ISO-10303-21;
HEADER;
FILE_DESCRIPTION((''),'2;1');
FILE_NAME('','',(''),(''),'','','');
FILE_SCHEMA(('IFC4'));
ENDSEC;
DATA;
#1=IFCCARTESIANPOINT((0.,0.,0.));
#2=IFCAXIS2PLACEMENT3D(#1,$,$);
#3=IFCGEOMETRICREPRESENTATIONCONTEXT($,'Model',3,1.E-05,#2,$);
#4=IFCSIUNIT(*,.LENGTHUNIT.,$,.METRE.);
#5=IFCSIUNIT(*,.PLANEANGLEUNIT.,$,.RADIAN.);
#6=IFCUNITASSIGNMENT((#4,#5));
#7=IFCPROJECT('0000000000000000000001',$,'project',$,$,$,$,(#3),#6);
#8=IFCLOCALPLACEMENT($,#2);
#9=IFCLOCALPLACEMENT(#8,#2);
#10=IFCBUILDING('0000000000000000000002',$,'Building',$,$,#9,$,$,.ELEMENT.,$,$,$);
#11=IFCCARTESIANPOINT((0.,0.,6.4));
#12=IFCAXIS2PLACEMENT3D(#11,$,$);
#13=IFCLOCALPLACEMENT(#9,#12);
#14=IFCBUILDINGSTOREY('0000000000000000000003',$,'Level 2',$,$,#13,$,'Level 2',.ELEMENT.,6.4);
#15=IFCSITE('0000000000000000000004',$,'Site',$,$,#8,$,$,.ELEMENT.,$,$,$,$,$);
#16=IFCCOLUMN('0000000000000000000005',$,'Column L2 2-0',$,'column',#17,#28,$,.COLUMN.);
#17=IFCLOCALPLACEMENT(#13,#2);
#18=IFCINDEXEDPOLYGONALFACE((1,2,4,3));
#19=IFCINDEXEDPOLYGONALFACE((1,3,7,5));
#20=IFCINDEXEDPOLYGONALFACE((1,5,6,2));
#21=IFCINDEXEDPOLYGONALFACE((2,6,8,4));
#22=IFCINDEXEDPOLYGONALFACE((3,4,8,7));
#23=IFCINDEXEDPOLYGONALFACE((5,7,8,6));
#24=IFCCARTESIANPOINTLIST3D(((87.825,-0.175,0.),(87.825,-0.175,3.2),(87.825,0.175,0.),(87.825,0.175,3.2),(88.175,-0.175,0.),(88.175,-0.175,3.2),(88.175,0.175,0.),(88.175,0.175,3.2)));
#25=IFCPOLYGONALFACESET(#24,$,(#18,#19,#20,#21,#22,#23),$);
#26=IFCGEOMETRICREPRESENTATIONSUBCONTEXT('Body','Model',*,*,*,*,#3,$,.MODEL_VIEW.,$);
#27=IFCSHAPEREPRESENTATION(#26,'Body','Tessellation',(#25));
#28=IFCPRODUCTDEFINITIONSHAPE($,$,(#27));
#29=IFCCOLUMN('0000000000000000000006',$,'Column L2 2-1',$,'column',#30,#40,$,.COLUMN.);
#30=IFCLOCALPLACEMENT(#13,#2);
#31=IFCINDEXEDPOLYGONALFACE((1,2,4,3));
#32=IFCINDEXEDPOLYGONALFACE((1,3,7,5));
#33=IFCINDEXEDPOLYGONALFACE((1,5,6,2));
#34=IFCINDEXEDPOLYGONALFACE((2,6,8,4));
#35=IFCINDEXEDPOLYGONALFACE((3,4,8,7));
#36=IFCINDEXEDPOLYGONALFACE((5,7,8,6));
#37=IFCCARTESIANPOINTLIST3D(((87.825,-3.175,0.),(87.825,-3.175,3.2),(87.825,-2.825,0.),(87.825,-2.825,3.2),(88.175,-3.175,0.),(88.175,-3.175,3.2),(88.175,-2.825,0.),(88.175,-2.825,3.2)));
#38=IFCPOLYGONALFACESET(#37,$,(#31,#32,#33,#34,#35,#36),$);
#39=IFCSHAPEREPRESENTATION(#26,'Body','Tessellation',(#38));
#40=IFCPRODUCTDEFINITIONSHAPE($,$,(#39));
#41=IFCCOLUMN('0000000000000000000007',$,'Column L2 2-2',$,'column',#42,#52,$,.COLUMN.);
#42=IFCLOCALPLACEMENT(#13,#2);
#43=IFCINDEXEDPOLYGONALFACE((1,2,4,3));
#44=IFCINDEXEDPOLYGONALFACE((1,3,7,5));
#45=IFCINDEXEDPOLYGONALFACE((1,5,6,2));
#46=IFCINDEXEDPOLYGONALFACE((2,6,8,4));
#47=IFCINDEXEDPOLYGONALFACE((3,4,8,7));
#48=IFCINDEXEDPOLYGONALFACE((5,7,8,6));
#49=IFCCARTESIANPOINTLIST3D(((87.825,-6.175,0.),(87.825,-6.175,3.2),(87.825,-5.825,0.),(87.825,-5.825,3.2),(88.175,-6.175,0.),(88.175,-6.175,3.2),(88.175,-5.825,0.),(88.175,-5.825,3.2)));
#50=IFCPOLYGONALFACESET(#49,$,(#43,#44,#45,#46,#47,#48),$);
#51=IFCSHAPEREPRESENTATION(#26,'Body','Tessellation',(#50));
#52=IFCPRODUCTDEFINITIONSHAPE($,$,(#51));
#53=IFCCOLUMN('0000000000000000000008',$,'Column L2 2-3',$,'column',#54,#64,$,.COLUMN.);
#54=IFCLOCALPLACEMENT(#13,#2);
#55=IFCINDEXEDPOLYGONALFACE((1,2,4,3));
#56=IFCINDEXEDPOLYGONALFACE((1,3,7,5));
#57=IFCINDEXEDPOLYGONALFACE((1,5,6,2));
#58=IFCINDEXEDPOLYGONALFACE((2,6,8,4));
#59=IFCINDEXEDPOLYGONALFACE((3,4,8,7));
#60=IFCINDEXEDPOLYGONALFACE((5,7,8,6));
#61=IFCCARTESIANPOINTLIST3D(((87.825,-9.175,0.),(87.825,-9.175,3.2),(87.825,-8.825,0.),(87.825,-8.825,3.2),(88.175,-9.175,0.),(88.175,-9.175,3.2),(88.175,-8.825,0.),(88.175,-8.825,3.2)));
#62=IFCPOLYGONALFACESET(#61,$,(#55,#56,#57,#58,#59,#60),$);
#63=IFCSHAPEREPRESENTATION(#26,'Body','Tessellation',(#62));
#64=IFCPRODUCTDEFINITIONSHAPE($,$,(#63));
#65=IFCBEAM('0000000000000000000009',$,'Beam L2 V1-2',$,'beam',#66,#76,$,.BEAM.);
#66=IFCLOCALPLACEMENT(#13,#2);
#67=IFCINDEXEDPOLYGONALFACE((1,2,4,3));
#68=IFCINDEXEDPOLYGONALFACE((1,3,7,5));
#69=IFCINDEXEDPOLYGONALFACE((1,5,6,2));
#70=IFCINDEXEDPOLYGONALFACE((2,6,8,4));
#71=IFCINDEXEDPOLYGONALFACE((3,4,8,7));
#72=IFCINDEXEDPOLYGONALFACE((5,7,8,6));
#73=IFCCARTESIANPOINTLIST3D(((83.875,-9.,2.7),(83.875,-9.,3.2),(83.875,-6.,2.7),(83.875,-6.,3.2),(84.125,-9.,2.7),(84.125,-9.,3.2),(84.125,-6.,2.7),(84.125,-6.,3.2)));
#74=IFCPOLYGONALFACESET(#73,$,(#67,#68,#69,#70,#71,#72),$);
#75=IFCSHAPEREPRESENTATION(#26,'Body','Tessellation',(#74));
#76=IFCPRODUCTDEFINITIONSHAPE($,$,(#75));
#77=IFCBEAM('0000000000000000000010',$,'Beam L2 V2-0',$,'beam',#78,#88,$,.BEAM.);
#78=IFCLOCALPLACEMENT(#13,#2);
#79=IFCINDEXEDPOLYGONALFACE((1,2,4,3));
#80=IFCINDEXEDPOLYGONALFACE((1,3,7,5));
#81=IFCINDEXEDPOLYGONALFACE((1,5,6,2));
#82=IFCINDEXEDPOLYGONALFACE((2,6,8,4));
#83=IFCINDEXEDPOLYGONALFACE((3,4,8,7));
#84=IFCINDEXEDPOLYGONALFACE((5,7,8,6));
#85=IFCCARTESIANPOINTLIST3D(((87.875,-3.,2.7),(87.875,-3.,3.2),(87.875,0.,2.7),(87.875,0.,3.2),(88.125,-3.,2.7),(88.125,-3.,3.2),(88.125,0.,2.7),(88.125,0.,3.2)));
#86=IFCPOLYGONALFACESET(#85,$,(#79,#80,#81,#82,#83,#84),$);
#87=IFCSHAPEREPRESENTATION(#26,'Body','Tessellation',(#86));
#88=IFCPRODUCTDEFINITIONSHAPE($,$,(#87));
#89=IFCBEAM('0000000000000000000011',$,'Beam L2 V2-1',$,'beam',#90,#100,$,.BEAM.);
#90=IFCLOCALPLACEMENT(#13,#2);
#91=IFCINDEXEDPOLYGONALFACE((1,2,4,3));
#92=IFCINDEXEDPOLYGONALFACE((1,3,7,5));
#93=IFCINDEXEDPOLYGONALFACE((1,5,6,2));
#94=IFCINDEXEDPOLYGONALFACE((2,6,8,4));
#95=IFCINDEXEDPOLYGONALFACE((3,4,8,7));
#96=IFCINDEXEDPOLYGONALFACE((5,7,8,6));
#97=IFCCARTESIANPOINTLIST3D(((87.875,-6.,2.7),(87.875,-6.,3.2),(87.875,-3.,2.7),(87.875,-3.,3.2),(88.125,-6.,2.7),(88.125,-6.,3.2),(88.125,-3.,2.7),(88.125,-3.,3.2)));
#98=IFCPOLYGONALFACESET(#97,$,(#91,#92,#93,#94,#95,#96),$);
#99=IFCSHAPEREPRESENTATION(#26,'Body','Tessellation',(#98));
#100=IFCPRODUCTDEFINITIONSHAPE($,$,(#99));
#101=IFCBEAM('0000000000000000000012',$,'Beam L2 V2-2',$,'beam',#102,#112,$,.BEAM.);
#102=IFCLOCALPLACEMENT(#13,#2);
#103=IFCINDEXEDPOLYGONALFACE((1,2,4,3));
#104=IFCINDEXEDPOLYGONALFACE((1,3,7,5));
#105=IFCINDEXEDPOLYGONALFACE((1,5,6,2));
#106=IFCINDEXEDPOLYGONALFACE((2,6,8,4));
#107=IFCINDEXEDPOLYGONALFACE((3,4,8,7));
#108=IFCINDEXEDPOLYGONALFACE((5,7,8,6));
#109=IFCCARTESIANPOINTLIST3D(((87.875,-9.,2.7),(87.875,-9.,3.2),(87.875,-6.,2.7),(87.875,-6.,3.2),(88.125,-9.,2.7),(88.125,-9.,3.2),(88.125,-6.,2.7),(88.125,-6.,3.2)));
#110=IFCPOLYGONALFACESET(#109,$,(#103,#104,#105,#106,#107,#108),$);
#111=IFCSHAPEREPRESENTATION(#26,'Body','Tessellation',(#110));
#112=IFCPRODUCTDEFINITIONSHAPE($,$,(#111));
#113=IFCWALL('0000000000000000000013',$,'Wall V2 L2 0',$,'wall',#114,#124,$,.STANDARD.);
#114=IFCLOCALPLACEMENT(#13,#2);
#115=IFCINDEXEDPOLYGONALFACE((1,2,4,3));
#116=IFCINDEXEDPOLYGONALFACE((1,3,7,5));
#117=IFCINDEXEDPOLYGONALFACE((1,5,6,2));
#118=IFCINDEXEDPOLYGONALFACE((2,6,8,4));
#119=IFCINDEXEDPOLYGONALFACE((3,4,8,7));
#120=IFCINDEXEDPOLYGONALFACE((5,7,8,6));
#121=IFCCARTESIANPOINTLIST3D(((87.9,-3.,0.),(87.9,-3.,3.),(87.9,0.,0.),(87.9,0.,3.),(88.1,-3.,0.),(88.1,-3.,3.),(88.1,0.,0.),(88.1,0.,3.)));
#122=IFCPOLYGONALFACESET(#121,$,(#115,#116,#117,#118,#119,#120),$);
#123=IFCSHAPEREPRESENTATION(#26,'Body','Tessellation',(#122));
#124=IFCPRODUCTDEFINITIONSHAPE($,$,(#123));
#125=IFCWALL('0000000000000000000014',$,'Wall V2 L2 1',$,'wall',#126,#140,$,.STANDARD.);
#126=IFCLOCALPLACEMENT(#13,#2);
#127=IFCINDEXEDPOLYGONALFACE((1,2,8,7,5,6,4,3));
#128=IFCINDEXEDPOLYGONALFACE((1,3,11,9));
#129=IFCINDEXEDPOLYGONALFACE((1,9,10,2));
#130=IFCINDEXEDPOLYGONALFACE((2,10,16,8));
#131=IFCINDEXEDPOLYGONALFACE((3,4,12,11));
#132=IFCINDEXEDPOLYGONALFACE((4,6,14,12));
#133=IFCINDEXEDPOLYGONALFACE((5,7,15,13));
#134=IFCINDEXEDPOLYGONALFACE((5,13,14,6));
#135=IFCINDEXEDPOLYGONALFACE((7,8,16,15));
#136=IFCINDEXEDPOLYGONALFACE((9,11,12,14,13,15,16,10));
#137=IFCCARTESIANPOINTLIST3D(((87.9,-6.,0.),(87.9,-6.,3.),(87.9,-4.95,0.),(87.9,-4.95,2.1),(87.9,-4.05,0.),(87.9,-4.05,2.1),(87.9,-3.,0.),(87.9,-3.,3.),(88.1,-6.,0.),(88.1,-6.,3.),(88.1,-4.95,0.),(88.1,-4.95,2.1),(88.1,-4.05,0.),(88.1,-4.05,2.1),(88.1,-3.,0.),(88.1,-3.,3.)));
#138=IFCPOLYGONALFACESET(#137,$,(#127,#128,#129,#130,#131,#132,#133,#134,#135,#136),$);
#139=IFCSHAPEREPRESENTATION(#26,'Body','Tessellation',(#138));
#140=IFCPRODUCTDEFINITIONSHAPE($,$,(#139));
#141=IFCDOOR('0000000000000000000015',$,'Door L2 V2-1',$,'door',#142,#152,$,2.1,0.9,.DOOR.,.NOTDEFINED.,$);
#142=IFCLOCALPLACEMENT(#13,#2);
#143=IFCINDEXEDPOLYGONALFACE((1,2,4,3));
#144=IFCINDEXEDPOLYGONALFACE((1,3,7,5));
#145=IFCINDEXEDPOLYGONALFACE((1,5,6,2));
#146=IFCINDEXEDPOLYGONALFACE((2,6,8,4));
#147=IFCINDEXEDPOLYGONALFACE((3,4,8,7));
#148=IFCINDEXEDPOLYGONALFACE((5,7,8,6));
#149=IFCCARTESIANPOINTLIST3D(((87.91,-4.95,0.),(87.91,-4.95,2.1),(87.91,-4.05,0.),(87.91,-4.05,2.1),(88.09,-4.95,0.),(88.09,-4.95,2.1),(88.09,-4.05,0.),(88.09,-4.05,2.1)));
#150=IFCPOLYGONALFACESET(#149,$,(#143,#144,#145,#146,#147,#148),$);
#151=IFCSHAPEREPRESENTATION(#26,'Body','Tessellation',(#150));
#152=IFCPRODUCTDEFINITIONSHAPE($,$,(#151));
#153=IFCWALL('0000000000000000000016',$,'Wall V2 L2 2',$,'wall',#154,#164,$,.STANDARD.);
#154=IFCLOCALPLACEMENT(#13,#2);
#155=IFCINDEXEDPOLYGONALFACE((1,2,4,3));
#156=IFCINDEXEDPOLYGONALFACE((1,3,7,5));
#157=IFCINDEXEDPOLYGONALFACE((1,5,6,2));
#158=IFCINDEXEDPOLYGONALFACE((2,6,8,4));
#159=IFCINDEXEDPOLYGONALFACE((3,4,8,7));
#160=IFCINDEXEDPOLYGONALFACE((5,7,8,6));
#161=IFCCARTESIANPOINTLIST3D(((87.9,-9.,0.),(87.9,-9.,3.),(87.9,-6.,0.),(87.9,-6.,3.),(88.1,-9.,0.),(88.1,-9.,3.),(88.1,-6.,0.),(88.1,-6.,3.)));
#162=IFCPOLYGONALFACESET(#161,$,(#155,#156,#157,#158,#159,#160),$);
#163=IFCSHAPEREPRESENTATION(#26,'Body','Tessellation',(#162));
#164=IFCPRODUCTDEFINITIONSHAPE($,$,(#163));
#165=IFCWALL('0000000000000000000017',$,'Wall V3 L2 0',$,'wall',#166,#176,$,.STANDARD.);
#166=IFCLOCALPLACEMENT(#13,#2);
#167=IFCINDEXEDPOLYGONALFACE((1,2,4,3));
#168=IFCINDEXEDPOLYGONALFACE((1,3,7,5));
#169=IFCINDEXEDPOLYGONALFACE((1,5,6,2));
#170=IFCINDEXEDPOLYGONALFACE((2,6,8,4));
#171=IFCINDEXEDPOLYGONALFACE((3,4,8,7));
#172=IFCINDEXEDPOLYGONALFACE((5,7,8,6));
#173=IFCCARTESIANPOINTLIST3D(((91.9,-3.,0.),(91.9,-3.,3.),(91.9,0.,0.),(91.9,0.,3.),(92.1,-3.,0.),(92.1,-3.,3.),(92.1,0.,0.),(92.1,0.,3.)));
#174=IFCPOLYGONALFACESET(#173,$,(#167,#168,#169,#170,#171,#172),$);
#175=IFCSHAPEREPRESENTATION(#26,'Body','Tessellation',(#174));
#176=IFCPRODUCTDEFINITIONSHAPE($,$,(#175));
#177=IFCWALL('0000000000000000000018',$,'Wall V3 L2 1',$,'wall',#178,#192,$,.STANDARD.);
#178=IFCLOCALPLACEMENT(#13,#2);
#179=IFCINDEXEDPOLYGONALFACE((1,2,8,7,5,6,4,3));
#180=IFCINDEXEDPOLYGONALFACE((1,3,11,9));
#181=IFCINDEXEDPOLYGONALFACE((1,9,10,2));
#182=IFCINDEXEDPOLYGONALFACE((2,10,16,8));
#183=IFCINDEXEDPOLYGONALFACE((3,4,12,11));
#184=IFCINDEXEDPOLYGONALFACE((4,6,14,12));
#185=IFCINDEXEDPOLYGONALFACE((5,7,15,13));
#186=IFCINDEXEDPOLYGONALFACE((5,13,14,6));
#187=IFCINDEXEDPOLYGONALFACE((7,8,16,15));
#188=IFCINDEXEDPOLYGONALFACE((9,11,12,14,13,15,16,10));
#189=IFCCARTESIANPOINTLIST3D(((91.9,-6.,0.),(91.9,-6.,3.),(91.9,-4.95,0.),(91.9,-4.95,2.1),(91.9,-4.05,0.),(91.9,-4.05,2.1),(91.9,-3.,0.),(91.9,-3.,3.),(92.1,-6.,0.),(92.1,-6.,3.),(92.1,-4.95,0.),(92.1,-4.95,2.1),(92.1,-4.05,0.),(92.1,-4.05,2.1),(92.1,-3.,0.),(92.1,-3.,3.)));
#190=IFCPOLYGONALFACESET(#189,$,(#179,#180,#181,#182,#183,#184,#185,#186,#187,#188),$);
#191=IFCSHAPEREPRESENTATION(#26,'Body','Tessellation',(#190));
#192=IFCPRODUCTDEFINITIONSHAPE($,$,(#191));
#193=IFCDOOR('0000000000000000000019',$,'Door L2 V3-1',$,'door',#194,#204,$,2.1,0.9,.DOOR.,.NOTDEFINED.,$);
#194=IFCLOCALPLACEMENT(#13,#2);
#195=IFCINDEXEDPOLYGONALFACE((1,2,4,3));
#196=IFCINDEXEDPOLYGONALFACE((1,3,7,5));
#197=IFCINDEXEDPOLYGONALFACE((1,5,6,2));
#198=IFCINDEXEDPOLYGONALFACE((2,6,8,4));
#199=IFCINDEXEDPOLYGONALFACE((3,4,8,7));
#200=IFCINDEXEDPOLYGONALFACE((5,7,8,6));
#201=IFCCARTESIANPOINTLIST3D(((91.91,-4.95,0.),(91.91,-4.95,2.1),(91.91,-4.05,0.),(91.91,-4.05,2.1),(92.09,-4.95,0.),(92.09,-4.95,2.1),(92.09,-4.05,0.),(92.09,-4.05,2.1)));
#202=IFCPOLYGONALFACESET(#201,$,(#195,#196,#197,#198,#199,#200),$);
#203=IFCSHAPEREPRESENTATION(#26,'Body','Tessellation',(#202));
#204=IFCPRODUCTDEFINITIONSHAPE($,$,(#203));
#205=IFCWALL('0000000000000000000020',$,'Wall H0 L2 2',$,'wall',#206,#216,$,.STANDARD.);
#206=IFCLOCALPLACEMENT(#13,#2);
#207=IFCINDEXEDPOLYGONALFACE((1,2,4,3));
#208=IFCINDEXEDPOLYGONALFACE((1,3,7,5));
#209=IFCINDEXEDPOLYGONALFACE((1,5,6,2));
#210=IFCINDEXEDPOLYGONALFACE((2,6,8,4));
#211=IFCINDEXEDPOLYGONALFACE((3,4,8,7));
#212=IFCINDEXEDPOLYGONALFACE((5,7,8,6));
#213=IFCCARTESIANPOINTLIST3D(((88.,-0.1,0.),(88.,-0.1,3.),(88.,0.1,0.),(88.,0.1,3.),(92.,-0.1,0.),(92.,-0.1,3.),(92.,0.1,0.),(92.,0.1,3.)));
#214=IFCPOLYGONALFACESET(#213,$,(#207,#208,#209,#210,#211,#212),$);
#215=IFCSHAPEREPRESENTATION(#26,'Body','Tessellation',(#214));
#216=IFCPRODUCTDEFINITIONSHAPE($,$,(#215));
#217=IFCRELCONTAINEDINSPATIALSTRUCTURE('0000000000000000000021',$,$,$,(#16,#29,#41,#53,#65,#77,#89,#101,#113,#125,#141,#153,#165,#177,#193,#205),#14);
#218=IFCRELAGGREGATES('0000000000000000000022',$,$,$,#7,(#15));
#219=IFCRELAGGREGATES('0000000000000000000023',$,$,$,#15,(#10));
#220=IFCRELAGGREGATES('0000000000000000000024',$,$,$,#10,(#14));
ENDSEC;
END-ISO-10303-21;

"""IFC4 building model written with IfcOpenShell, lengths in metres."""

from ifc_helpers import new_model, si_unit, frame, frame_2d, origin, origin_2d, place, context, subcontext, project, spatial, rectangle, extrude, element, fill, save


model = new_model("IFC4")

# Units and contexts
model_context = context("Model", 3, precision=1e-05, world=origin())
body_context = subcontext(model_context, "Body", "Model", "MODEL_VIEW")
ifc_project = project(units=[si_unit("LENGTHUNIT", "METRE"), si_unit("PLANEANGLEUNIT", "RADIAN")], contexts=[model_context])

# Site, building, storey
site_placement = place(None, origin())
site = spatial("IfcSite", under=ifc_project, at=site_placement, Name="Site", CompositionType="ELEMENT")
building_placement = place(site_placement, origin())
building = spatial("IfcBuilding", under=site, at=building_placement, Name="Building", CompositionType="ELEMENT")
storey_placement = place(building_placement, frame((0.0, 0.0, 6.4)))
storey = spatial("IfcBuildingStorey", under=building, at=storey_placement, Name="Level 2", LongName="Level 2", CompositionType="ELEMENT", Elevation=6.4)

# Columns
for number, where, name in (
    (1, (88.0, 0.0, 0.0), "Column L2 2-0"),
    (2, (88.0, -3.0, 0.0), "Column L2 2-1"),
    (3, (88.0, -6.0, 0.0), "Column L2 2-2"),
    (4, (88.0, -9.0, 0.0), "Column L2 2-3"),
):
    element("IfcColumn", number, at=place(storey_placement, frame(where)), inside=storey, Name=name, ObjectType="column", PredefinedType="COLUMN", context=body_context, shape_type="SweptSolid", body=[
        extrude(rectangle(XDim=0.35, YDim=0.35, at=origin_2d()), origin(), (0.0, 0.0, 1.0), 3.2),
    ])

# Beams
for number, where, z_axis, x_axis, name in (
    (5, (84.0, -6.0, 2.95), (0.0, -1.0, 0.0), (0.0, 0.0, 1.0), "Beam L2 V1-2"),
    (6, (88.0, 0.0, 2.95), (0.0, -1.0, 0.0), (0.0, 0.0, 1.0), "Beam L2 V2-0"),
    (7, (88.0, -3.0, 2.95), (0.0, -1.0, 0.0), (0.0, 0.0, 1.0), "Beam L2 V2-1"),
    (8, (88.0, -6.0, 2.95), (0.0, -1.0, 0.0), (0.0, 0.0, 1.0), "Beam L2 V2-2"),
):
    element("IfcBeam", number, at=place(storey_placement, frame(where, z_axis=z_axis, x_axis=x_axis)), inside=storey, Name=name, ObjectType="beam", PredefinedType="BEAM", context=body_context, shape_type="SweptSolid", body=[
        extrude(rectangle(XDim=0.5, YDim=0.25, at=origin_2d()), origin(), (0.0, 0.0, 1.0), 3.0),
    ])

# Wall
wall_1_placement = place(storey_placement, frame((88.0, 0.0, 0.0), z_axis=(0.0, 0.0, 1.0), x_axis=(0.0, -1.0, 0.0)))
element("IfcWall", 9, at=wall_1_placement, inside=storey, Name="Wall V2 L2 0", ObjectType="wall", PredefinedType="STANDARD", context=body_context, shape_type="SweptSolid", body=[
    extrude(rectangle(XDim=3.0, YDim=0.2, at=frame_2d((1.5, 0.0))), origin(), (0.0, 0.0, 1.0), 3.0),
])

# Wall, opening, door
wall_2_placement = place(storey_placement, frame((88.0, -3.0, 0.0), z_axis=(0.0, 0.0, 1.0), x_axis=(0.0, -1.0, 0.0)))
wall_2 = element("IfcWall", 10, at=wall_2_placement, inside=storey, Name="Wall V2 L2 1", ObjectType="wall", PredefinedType="STANDARD", context=body_context, shape_type="SweptSolid", body=[
    extrude(rectangle(XDim=3.0, YDim=0.2, at=frame_2d((1.5, 0.0))), origin(), (0.0, 0.0, 1.0), 3.0),
])
opening_1_placement = place(storey_placement, frame((88.0, -4.5, 0.0), z_axis=(0.0, 0.0, 1.0), x_axis=(0.0, -1.0, 0.0)))
opening_1 = element("IfcOpeningElement", 11, at=opening_1_placement, cuts=wall_2, ObjectType="Opening", PredefinedType="OPENING", context=body_context, shape_type="SweptSolid", body=[
    extrude(rectangle(XDim=0.9, YDim=0.22, at=origin_2d()), origin(), (0.0, 0.0, 1.0), 2.1),
])
door_1_placement = place(storey_placement, frame((88.0, -4.5, 0.0), z_axis=(0.0, 0.0, 1.0), x_axis=(0.0, -1.0, 0.0)))
door_1 = element("IfcDoor", 12, at=door_1_placement, inside=storey, Name="Door L2 V2-1", ObjectType="door", OperationType="NOTDEFINED", OverallHeight=2.1, OverallWidth=0.9, PredefinedType="DOOR", context=body_context, shape_type="SweptSolid", body=[
    extrude(rectangle(XDim=0.9, YDim=0.18, at=origin_2d()), origin(), (0.0, 0.0, 1.0), 2.1),
])
fill(opening_1, door_1)

# Walls
for number, where, z_axis, x_axis, name in (
    (13, (88.0, -6.0, 0.0), (0.0, 0.0, 1.0), (0.0, -1.0, 0.0), "Wall V2 L2 2"),
    (14, (92.0, 0.0, 0.0), (0.0, 0.0, 1.0), (0.0, -1.0, 0.0), "Wall V3 L2 0"),
):
    element("IfcWall", number, at=place(storey_placement, frame(where, z_axis=z_axis, x_axis=x_axis)), inside=storey, Name=name, ObjectType="wall", PredefinedType="STANDARD", context=body_context, shape_type="SweptSolid", body=[
        extrude(rectangle(XDim=3.0, YDim=0.2, at=frame_2d((1.5, 0.0))), origin(), (0.0, 0.0, 1.0), 3.0),
    ])

# Wall, opening, door
wall_3_placement = place(storey_placement, frame((92.0, -3.0, 0.0), z_axis=(0.0, 0.0, 1.0), x_axis=(0.0, -1.0, 0.0)))
wall_3 = element("IfcWall", 15, at=wall_3_placement, inside=storey, Name="Wall V3 L2 1", ObjectType="wall", PredefinedType="STANDARD", context=body_context, shape_type="SweptSolid", body=[
    extrude(rectangle(XDim=3.0, YDim=0.2, at=frame_2d((1.5, 0.0))), origin(), (0.0, 0.0, 1.0), 3.0),
])
opening_2_placement = place(storey_placement, frame((92.0, -4.5, 0.0), z_axis=(0.0, 0.0, 1.0), x_axis=(0.0, -1.0, 0.0)))
opening_2 = element("IfcOpeningElement", 16, at=opening_2_placement, cuts=wall_3, ObjectType="Opening", PredefinedType="OPENING", context=body_context, shape_type="SweptSolid", body=[
    extrude(rectangle(XDim=0.9, YDim=0.22, at=origin_2d()), origin(), (0.0, 0.0, 1.0), 2.1),
])
door_2_placement = place(storey_placement, frame((92.0, -4.5, 0.0), z_axis=(0.0, 0.0, 1.0), x_axis=(0.0, -1.0, 0.0)))
door_2 = element("IfcDoor", 17, at=door_2_placement, inside=storey, Name="Door L2 V3-1", ObjectType="door", OperationType="NOTDEFINED", OverallHeight=2.1, OverallWidth=0.9, PredefinedType="DOOR", context=body_context, shape_type="SweptSolid", body=[
    extrude(rectangle(XDim=0.9, YDim=0.18, at=origin_2d()), origin(), (0.0, 0.0, 1.0), 2.1),
])
fill(opening_2, door_2)

# Wall
wall_4_placement = place(storey_placement, frame((88.0, 0.0, 0.0), z_axis=(0.0, 0.0, 1.0), x_axis=(1.0, 0.0, 0.0)))
element("IfcWall", 18, at=wall_4_placement, inside=storey, Name="Wall H0 L2 2", ObjectType="wall", PredefinedType="STANDARD", context=body_context, shape_type="SweptSolid", body=[
    extrude(rectangle(XDim=4.0, YDim=0.2, at=frame_2d((2.0, 0.0))), origin(), (0.0, 0.0, 1.0), 3.0),
])

save(model, "model.ifc")
